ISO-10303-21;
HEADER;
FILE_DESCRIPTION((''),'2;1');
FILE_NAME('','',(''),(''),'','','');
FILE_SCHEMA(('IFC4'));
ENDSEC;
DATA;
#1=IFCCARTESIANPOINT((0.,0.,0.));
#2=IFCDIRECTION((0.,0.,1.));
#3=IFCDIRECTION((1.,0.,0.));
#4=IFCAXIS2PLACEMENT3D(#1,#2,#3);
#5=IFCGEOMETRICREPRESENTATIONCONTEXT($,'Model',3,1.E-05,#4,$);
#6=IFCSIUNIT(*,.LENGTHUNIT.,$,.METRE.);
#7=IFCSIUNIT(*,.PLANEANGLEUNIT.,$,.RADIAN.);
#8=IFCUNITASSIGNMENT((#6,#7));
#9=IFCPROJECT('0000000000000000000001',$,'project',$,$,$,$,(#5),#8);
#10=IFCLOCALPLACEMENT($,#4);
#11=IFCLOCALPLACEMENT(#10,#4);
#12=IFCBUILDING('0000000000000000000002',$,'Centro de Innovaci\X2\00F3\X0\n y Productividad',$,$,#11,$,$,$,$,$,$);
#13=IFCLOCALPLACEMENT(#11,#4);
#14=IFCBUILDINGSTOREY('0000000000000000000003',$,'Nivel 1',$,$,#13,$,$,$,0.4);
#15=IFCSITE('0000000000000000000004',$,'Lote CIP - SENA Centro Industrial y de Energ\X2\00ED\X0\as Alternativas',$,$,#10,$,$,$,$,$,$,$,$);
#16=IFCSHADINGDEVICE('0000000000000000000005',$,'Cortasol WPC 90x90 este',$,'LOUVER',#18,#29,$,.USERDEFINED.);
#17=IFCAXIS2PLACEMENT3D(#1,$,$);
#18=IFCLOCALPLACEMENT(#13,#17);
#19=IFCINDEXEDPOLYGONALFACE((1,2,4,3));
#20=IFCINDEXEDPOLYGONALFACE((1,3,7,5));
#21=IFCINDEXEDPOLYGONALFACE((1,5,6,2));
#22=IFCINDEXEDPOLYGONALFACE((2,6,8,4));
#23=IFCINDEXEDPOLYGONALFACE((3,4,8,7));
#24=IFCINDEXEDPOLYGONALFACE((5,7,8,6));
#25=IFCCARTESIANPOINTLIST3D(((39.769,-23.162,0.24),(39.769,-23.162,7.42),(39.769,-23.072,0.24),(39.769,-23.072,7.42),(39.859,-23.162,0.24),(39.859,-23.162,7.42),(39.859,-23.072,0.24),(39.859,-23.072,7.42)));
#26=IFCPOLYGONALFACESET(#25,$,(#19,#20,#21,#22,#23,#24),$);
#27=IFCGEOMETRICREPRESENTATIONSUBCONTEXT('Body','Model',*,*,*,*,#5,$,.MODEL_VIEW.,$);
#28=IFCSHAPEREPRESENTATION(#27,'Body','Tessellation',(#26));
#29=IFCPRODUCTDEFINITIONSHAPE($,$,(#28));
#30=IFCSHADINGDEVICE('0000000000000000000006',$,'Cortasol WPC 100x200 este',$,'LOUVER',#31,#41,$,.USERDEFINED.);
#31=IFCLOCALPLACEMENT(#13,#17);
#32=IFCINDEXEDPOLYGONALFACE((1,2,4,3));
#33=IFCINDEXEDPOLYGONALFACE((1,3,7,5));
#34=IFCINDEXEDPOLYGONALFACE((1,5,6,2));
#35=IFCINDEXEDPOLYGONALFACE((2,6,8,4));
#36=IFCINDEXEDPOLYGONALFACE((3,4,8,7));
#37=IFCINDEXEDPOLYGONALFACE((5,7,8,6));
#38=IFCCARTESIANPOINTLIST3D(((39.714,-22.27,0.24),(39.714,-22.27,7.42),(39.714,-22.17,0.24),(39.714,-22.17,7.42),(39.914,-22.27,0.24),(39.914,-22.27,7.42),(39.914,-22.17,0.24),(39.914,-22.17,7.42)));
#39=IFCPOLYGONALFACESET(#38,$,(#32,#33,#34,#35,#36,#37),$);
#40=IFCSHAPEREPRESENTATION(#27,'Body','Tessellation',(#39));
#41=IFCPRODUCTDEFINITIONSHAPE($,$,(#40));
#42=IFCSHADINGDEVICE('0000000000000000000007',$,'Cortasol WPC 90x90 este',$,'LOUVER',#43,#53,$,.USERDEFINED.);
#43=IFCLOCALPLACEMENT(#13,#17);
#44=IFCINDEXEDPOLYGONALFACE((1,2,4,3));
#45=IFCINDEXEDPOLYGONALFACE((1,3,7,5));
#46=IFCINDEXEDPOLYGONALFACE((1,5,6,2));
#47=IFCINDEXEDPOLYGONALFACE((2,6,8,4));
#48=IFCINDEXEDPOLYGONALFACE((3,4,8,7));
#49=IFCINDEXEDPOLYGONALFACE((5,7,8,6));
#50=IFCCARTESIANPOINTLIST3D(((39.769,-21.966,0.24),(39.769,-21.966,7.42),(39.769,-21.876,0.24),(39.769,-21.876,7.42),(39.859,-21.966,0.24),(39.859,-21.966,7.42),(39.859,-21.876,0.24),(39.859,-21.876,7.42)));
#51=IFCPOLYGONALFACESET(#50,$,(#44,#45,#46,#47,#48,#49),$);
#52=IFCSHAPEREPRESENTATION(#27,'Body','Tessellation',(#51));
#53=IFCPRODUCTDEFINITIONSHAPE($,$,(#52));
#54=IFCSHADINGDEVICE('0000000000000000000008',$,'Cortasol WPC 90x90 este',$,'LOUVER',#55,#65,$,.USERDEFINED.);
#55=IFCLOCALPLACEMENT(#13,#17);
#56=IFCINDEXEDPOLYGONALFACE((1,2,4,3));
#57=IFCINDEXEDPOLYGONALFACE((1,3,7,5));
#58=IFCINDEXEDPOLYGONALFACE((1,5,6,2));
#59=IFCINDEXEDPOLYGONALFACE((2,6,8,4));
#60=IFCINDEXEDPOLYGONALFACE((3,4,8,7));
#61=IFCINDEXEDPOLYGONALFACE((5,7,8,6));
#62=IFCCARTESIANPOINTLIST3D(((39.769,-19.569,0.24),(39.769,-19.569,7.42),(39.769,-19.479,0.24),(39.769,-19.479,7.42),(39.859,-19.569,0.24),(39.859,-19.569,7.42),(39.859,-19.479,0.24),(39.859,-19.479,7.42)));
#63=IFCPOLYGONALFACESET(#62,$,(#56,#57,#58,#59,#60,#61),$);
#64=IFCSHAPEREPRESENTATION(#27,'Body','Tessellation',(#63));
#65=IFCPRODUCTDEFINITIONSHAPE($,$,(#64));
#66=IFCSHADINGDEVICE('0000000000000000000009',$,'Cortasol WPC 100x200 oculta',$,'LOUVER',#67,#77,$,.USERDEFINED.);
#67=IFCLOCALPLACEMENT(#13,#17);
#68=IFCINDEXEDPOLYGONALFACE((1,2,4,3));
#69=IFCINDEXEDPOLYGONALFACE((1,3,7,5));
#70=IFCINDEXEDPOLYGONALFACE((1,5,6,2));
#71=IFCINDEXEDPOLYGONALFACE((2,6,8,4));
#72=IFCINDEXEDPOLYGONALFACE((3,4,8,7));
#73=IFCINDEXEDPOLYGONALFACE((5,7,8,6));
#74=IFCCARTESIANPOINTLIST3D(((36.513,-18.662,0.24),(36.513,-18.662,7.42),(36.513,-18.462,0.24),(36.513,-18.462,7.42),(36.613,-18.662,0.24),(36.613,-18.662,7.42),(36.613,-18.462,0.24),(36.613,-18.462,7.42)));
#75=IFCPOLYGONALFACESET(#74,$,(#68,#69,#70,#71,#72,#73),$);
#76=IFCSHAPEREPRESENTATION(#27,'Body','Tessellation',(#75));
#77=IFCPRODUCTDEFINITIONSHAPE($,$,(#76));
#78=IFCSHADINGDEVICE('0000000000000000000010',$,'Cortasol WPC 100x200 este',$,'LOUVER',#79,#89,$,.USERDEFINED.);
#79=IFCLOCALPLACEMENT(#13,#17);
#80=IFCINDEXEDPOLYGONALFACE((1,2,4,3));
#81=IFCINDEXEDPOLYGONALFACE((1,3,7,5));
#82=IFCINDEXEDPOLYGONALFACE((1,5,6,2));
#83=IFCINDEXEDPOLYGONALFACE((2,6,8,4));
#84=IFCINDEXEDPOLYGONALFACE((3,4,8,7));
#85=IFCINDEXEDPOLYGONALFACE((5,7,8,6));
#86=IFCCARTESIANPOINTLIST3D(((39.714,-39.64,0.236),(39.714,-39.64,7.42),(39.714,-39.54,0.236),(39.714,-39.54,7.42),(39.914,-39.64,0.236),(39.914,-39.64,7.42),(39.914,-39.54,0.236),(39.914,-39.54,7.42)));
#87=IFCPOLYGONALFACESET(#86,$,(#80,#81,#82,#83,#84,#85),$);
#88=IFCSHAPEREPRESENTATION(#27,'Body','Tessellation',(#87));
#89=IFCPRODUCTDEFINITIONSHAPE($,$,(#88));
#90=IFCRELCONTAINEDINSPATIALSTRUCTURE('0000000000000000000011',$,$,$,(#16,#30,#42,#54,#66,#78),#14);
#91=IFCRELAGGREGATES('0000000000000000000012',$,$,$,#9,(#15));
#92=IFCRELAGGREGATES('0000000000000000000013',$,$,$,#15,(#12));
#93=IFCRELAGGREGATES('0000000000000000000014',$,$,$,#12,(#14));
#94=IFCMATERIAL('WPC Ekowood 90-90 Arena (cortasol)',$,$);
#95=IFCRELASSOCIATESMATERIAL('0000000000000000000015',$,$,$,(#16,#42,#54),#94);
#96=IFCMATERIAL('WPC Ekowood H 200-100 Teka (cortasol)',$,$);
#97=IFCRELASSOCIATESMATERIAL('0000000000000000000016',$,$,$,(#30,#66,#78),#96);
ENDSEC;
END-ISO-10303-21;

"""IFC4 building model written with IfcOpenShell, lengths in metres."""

from ifc_helpers import new_model, si_unit, frame, origin_with_axes, place, context, subcontext, project, spatial, polyline, outline, extrude, material, element, save


model = new_model("IFC4")

# Units and contexts
model_context = context("Model", 3, precision=1e-05, world=origin_with_axes())
body_context = subcontext(model_context, "Body", "Model", "MODEL_VIEW")
ifc_project = project(units=[si_unit("LENGTHUNIT", "METRE"), si_unit("PLANEANGLEUNIT", "RADIAN")], contexts=[model_context])

# Site, building, storey
site_placement = place(None, origin_with_axes())
site = spatial("IfcSite", under=ifc_project, at=site_placement, Name="Lote CIP - SENA Centro Industrial y de Energías Alternativas")
building_placement = place(site_placement, origin_with_axes())
building = spatial("IfcBuilding", under=site, at=building_placement, Name="Centro de Innovación y Productividad")
storey_placement = place(building_placement, origin_with_axes())
storey = spatial("IfcBuildingStorey", under=building, at=storey_placement, Name="Nivel 1", Elevation=0.4)

# Shading devices
ifc_material_1 = material(Name="WPC Ekowood 90-90 Arena (cortasol)")
ifc_material_2 = material(Name="WPC Ekowood H 200-100 Teka (cortasol)")
shading_device_1_placement = place(storey_placement, origin_with_axes())
element("IfcShadingDevice", 1, at=shading_device_1_placement, inside=storey, material=ifc_material_1, Name="Cortasol WPC 90x90 este", ObjectType="LOUVER", PredefinedType="USERDEFINED", context=body_context, shape_type="SweptSolid", body=[
    extrude(outline(polyline([(39.859, -23.162), (39.769, -23.162), (39.769, -23.072), (39.859, -23.072), (39.859, -23.162)])), frame((0.0, 0.0, 0.24)), (0.0, 0.0, 1.0), 7.18),
])
shading_device_2_placement = place(storey_placement, origin_with_axes())
element("IfcShadingDevice", 2, at=shading_device_2_placement, inside=storey, material=ifc_material_2, Name="Cortasol WPC 100x200 este", ObjectType="LOUVER", PredefinedType="USERDEFINED", context=body_context, shape_type="SweptSolid", body=[
    extrude(outline(polyline([(39.914, -22.27), (39.714, -22.27), (39.714, -22.17), (39.914, -22.17), (39.914, -22.27)])), frame((0.0, 0.0, 0.24)), (0.0, 0.0, 1.0), 7.18),
])
shading_device_3_placement = place(storey_placement, origin_with_axes())
element("IfcShadingDevice", 3, at=shading_device_3_placement, inside=storey, material=ifc_material_1, Name="Cortasol WPC 90x90 este", ObjectType="LOUVER", PredefinedType="USERDEFINED", context=body_context, shape_type="SweptSolid", body=[
    extrude(outline(polyline([(39.859, -21.966), (39.769, -21.966), (39.769, -21.876), (39.859, -21.876), (39.859, -21.966)])), frame((0.0, 0.0, 0.24)), (0.0, 0.0, 1.0), 7.18),
])
shading_device_4_placement = place(storey_placement, origin_with_axes())
element("IfcShadingDevice", 4, at=shading_device_4_placement, inside=storey, material=ifc_material_1, Name="Cortasol WPC 90x90 este", ObjectType="LOUVER", PredefinedType="USERDEFINED", context=body_context, shape_type="SweptSolid", body=[
    extrude(outline(polyline([(39.859, -19.569), (39.769, -19.569), (39.769, -19.479), (39.859, -19.479), (39.859, -19.569)])), frame((0.0, 0.0, 0.24)), (0.0, 0.0, 1.0), 7.18),
])
shading_device_5_placement = place(storey_placement, origin_with_axes())
element("IfcShadingDevice", 5, at=shading_device_5_placement, inside=storey, material=ifc_material_2, Name="Cortasol WPC 100x200 oculta", ObjectType="LOUVER", PredefinedType="USERDEFINED", context=body_context, shape_type="SweptSolid", body=[
    extrude(outline(polyline([(36.513, -18.662), (36.513, -18.462), (36.613, -18.462), (36.613, -18.662), (36.513, -18.662)])), frame((0.0, 0.0, 0.24)), (0.0, 0.0, 1.0), 7.18),
])
shading_device_6_placement = place(storey_placement, origin_with_axes())
element("IfcShadingDevice", 6, at=shading_device_6_placement, inside=storey, material=ifc_material_2, Name="Cortasol WPC 100x200 este", ObjectType="LOUVER", PredefinedType="USERDEFINED", context=body_context, shape_type="SweptSolid", body=[
    extrude(outline(polyline([(39.914, -39.64), (39.714, -39.64), (39.714, -39.54), (39.914, -39.54), (39.914, -39.64)])), frame((0.0, 0.0, 0.236)), (0.0, 0.0, 1.0), 7.184),
])

save(model, "model.ifc")
